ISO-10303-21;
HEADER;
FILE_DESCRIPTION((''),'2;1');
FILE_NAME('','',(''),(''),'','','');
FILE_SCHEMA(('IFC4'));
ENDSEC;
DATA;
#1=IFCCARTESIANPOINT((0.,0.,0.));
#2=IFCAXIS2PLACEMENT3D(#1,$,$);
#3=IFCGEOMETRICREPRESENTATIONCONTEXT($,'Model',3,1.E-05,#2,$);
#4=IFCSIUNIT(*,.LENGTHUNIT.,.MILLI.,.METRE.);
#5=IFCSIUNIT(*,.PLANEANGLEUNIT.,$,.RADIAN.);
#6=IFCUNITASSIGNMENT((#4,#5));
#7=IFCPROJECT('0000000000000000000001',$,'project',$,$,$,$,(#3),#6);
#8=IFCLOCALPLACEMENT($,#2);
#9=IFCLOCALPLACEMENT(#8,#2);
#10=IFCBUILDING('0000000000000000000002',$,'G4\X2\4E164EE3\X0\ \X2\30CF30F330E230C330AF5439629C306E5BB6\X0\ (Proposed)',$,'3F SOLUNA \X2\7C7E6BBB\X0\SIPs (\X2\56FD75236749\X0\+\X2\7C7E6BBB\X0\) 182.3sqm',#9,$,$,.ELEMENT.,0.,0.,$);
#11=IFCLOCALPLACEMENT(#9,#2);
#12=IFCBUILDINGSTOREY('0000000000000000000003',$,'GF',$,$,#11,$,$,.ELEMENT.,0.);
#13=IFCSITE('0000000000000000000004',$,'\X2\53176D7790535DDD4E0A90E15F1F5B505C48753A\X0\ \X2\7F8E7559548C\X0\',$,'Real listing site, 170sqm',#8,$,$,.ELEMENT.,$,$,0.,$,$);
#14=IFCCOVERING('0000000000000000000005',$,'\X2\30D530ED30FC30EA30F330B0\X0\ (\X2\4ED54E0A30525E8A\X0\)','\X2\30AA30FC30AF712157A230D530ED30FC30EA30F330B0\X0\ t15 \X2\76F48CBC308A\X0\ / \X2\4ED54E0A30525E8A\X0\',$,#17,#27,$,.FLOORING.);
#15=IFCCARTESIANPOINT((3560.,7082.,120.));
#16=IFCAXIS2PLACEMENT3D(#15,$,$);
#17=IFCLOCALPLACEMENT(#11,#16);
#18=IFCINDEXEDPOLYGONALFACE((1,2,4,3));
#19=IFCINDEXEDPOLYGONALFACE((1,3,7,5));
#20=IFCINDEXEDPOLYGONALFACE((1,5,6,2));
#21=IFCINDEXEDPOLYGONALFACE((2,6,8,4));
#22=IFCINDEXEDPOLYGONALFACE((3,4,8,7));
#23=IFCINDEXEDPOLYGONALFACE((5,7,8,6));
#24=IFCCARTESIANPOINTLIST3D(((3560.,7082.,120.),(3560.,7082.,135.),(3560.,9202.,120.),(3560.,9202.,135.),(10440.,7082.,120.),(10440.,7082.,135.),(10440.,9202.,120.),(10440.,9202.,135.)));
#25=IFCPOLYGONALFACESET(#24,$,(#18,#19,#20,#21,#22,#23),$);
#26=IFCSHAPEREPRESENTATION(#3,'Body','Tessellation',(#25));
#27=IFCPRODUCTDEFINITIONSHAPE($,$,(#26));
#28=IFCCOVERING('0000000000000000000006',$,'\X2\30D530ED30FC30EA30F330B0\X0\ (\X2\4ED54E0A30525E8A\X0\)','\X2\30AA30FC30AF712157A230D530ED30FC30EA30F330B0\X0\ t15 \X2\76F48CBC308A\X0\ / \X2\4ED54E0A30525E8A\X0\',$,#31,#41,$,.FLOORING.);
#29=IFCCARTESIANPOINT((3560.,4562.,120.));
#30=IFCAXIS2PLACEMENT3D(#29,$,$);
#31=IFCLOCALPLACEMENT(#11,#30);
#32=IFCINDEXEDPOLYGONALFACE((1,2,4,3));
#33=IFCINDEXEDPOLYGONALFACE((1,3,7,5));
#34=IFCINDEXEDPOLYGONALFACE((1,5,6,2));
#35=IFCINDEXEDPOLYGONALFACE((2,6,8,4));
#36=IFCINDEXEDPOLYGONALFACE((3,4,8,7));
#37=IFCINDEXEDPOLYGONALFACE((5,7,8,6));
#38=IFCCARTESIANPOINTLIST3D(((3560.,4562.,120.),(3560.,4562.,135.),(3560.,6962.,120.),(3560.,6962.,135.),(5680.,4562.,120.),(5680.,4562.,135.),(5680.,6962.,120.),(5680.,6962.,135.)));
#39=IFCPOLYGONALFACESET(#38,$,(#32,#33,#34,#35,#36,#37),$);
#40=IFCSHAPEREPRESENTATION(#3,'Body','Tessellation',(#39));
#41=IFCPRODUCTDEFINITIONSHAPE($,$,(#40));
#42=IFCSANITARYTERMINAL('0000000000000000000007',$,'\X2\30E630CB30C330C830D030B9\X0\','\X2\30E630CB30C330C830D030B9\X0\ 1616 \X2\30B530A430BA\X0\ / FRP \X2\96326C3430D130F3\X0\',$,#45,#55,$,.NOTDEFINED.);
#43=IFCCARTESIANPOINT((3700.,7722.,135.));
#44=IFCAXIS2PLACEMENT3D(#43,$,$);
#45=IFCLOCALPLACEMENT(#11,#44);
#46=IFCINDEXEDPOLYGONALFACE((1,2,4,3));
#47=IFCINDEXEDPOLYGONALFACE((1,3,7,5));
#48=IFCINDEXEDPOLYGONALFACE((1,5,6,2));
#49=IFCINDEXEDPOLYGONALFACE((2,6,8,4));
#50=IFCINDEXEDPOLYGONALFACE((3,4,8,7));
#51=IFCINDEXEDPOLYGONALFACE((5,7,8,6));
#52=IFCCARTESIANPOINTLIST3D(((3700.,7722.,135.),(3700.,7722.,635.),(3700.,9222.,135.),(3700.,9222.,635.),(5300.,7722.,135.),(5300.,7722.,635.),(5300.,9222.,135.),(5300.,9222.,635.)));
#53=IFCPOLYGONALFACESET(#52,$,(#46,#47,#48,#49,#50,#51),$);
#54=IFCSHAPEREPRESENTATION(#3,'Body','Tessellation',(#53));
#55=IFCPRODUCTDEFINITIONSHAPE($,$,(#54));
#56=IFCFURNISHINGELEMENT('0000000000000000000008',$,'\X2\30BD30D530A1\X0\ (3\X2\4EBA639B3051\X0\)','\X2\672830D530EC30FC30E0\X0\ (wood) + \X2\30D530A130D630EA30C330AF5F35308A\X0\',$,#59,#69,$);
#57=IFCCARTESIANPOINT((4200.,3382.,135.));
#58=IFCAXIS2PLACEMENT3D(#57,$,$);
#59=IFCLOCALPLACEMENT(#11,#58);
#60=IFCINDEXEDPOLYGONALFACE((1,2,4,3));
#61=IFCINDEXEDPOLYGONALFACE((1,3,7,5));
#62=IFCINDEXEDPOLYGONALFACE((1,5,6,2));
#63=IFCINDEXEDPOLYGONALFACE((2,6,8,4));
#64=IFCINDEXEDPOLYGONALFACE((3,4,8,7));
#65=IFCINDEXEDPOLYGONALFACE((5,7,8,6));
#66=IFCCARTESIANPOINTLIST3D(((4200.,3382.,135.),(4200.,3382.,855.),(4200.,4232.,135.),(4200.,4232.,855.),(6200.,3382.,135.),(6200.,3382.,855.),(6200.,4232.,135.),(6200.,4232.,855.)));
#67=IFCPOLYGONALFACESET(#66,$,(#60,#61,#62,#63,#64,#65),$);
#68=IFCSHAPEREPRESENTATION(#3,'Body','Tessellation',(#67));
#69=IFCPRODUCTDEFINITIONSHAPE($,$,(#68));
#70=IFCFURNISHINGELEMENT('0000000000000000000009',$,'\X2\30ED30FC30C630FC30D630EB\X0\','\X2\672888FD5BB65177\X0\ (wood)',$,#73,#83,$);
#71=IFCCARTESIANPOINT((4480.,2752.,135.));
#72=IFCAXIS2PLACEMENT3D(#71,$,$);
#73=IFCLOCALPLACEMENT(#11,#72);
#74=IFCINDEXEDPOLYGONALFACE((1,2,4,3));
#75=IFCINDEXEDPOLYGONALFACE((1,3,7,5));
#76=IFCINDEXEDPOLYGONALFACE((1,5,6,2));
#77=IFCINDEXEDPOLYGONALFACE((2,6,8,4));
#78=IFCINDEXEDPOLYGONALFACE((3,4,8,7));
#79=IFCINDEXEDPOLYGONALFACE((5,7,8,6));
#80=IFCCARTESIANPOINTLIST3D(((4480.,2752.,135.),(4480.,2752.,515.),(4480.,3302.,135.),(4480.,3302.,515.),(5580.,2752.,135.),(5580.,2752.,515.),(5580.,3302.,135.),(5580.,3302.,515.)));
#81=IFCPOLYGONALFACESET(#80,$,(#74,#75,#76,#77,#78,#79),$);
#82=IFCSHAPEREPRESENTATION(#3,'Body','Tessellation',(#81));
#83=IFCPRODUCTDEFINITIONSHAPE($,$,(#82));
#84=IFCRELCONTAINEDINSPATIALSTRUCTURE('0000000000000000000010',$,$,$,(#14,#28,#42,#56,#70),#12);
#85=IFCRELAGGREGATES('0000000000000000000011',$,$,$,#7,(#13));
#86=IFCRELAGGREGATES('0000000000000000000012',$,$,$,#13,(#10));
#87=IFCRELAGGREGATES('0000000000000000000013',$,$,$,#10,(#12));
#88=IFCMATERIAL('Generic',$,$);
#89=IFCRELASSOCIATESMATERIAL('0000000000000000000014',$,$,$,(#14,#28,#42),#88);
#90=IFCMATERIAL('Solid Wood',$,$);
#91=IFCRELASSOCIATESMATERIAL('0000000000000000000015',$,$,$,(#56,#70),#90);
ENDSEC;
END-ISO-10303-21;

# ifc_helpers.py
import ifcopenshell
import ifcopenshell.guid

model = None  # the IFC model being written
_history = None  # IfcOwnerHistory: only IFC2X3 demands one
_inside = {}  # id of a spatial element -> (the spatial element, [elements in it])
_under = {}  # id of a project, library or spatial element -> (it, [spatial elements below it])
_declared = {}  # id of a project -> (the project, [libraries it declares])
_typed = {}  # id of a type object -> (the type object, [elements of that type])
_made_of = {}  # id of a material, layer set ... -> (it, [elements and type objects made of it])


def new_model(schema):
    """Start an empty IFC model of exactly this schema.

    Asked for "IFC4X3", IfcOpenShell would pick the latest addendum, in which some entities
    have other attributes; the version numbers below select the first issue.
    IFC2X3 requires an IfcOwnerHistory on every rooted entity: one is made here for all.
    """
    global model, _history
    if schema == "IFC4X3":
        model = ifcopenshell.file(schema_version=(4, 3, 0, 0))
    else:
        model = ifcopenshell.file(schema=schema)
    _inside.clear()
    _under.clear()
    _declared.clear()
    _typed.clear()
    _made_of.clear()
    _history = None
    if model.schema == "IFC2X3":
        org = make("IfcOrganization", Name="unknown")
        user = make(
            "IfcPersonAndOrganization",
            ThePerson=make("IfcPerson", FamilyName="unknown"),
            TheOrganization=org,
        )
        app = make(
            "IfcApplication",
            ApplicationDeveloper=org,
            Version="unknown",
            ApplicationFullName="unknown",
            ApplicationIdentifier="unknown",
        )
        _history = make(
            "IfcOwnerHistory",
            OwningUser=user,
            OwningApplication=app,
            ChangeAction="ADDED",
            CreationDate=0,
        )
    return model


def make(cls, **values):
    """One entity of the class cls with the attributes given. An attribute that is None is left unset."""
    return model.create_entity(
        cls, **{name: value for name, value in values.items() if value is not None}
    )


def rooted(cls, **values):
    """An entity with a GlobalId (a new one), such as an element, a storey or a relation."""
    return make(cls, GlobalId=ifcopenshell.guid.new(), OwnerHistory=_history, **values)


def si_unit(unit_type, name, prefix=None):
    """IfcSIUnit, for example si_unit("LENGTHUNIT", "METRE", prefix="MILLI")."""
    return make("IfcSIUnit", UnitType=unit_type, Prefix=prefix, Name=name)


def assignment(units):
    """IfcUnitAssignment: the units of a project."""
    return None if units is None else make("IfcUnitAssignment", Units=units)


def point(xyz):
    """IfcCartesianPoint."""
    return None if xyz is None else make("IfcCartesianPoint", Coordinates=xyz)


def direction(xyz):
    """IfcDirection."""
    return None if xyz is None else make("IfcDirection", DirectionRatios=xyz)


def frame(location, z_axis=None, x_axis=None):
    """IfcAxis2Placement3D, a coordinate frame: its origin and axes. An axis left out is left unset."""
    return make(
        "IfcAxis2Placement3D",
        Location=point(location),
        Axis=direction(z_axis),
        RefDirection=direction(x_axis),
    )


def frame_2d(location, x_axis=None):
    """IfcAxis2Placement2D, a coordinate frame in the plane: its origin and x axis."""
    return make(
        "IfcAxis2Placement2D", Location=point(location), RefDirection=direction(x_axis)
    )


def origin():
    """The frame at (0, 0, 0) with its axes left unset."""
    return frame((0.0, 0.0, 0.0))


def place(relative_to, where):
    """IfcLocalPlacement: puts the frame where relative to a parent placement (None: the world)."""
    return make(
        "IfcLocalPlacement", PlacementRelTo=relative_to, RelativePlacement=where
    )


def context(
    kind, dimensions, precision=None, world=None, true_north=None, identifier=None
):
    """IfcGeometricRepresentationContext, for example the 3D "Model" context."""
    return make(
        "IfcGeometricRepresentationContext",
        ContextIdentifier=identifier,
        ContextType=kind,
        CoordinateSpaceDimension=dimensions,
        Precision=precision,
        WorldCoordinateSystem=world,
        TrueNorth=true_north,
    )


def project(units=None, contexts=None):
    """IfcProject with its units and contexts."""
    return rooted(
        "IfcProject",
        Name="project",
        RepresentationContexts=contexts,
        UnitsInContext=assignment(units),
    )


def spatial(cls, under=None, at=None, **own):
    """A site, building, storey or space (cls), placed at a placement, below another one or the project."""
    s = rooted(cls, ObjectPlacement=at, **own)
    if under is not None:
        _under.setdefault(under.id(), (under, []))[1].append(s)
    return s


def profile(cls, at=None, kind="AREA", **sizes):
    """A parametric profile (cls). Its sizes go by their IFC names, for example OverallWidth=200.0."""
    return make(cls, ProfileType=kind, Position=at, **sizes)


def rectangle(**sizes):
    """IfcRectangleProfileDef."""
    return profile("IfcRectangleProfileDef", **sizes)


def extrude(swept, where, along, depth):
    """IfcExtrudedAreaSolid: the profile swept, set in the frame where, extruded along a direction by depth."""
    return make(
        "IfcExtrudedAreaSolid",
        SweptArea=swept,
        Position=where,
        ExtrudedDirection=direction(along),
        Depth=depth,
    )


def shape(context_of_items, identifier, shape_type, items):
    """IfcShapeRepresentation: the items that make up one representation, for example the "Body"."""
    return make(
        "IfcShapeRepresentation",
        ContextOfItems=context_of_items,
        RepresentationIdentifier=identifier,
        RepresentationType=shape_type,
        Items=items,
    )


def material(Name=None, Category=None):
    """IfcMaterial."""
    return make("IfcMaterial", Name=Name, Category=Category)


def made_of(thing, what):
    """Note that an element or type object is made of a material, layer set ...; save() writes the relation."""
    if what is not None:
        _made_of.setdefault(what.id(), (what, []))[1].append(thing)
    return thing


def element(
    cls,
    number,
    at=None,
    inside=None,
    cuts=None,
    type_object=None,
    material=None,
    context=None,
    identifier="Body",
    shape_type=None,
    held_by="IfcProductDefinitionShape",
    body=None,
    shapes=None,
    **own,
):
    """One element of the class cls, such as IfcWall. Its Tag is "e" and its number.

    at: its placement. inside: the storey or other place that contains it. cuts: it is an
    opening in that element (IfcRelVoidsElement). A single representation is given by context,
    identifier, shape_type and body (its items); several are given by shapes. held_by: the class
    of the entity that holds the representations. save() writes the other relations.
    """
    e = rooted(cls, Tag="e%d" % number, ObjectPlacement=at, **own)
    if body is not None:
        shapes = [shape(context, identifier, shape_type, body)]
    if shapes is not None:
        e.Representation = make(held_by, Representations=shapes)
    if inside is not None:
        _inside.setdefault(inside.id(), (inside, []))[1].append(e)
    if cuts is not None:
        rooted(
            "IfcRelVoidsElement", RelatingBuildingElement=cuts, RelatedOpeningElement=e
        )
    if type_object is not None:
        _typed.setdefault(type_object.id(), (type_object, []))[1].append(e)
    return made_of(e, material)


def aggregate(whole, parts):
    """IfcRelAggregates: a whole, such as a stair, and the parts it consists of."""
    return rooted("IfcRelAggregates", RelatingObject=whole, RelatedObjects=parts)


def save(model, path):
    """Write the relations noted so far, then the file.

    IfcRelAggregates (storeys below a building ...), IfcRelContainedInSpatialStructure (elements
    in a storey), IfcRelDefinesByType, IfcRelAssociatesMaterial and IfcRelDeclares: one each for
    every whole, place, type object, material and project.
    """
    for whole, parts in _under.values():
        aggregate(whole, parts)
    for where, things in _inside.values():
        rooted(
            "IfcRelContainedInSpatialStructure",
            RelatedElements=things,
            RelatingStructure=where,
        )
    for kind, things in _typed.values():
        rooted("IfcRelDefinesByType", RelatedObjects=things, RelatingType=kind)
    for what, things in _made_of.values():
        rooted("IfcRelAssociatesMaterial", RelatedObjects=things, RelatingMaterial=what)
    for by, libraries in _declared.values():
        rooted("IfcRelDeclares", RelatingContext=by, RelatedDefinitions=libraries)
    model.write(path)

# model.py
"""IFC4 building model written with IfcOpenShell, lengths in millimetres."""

from ifc_helpers import new_model, si_unit, frame, frame_2d, origin, place, context, project, spatial, rectangle, extrude, material, element, save


model = new_model("IFC4")

# Units and contexts
model_context = context("Model", 3, precision=1e-05, world=origin())
ifc_project = project(units=[si_unit("LENGTHUNIT", "METRE", prefix="MILLI"), si_unit("PLANEANGLEUNIT", "RADIAN")], contexts=[model_context])

# Site, building, storey
site_placement = place(None, origin())
site = spatial("IfcSite", under=ifc_project, at=site_placement, Name="北海道川上郡弟子屈町 美留和", ObjectType="Real listing site, 170sqm", CompositionType="ELEMENT", RefElevation=0.0)
building_placement = place(site_placement, origin())
building = spatial("IfcBuilding", under=site, at=building_placement, Name="G4世代 ハンモック吹抜の家 (Proposed)", ObjectType="3F SOLUNA 籾殻SIPs (国産杉+籾殻) 182.3sqm", CompositionType="ELEMENT", ElevationOfRefHeight=0.0, ElevationOfTerrain=0.0)
storey_placement = place(building_placement, origin())
storey = spatial("IfcBuildingStorey", under=building, at=storey_placement, Name="GF", CompositionType="ELEMENT", Elevation=0.0)

# Shared definitions
ifc_material_1 = material(Name="Solid Wood")

# Coverings
ifc_material_2 = material(Name="Generic")
covering_1_placement = place(storey_placement, frame((3560.0, 7082.0, 120.0)))
element("IfcCovering", 1, at=covering_1_placement, inside=storey, material=ifc_material_2, Name="フローリング (仕上げ床)", Description="オーク無垢フローリング t15 直貼り / 仕上げ床", PredefinedType="FLOORING", context=model_context, shape_type="SweptSolid", body=[
    extrude(rectangle(XDim=6880.0, YDim=2120.0, at=frame_2d((3440.0, 1060.0))), frame((3560.0, 7082.0, 120.0)), (0.0, 0.0, 1.0), 15.0),
])
covering_2_placement = place(storey_placement, frame((3560.0, 4562.0, 120.0)))
element("IfcCovering", 2, at=covering_2_placement, inside=storey, material=ifc_material_2, Name="フローリング (仕上げ床)", Description="オーク無垢フローリング t15 直貼り / 仕上げ床", PredefinedType="FLOORING", context=model_context, shape_type="SweptSolid", body=[
    extrude(rectangle(XDim=2120.0, YDim=2400.0, at=frame_2d((1060.0, 1200.0))), frame((3560.0, 4562.0, 120.0)), (0.0, 0.0, 1.0), 15.0),
])

# Sanitary terminal
sanitary_terminal_placement = place(storey_placement, frame((3700.0, 7722.0, 135.0)))
element("IfcSanitaryTerminal", 3, at=sanitary_terminal_placement, inside=storey, material=ifc_material_2, Name="ユニットバス", Description="ユニットバス 1616 サイズ / FRP 防水パン", PredefinedType="NOTDEFINED", context=model_context, shape_type="SweptSolid", body=[
    extrude(rectangle(XDim=1600.0, YDim=1500.0, at=frame_2d((800.0, 750.0))), frame((3700.0, 7722.0, 135.0)), (0.0, 0.0, 1.0), 500.0),
])

# Furnishing elements
furnishing_1_placement = place(storey_placement, frame((4200.0, 3382.0, 135.0)))
element("IfcFurnishingElement", 4, at=furnishing_1_placement, inside=storey, material=ifc_material_1, Name="ソファ (3人掛け)", Description="木フレーム (wood) + ファブリック張り", context=model_context, shape_type="SweptSolid", body=[
    extrude(rectangle(XDim=2000.0, YDim=850.0, at=frame_2d((1000.0, 425.0))), frame((4200.0, 3382.0, 135.0)), (0.0, 0.0, 1.0), 720.0),
])
furnishing_2_placement = place(storey_placement, frame((4480.0, 2752.0, 135.0)))
element("IfcFurnishingElement", 5, at=furnishing_2_placement, inside=storey, material=ifc_material_1, Name="ローテーブル", Description="木製家具 (wood)", context=model_context, shape_type="SweptSolid", body=[
    extrude(rectangle(XDim=1100.0, YDim=550.0, at=frame_2d((550.0, 275.0))), frame((4480.0, 2752.0, 135.0)), (0.0, 0.0, 1.0), 380.0),
])

save(model, "model.ifc")
